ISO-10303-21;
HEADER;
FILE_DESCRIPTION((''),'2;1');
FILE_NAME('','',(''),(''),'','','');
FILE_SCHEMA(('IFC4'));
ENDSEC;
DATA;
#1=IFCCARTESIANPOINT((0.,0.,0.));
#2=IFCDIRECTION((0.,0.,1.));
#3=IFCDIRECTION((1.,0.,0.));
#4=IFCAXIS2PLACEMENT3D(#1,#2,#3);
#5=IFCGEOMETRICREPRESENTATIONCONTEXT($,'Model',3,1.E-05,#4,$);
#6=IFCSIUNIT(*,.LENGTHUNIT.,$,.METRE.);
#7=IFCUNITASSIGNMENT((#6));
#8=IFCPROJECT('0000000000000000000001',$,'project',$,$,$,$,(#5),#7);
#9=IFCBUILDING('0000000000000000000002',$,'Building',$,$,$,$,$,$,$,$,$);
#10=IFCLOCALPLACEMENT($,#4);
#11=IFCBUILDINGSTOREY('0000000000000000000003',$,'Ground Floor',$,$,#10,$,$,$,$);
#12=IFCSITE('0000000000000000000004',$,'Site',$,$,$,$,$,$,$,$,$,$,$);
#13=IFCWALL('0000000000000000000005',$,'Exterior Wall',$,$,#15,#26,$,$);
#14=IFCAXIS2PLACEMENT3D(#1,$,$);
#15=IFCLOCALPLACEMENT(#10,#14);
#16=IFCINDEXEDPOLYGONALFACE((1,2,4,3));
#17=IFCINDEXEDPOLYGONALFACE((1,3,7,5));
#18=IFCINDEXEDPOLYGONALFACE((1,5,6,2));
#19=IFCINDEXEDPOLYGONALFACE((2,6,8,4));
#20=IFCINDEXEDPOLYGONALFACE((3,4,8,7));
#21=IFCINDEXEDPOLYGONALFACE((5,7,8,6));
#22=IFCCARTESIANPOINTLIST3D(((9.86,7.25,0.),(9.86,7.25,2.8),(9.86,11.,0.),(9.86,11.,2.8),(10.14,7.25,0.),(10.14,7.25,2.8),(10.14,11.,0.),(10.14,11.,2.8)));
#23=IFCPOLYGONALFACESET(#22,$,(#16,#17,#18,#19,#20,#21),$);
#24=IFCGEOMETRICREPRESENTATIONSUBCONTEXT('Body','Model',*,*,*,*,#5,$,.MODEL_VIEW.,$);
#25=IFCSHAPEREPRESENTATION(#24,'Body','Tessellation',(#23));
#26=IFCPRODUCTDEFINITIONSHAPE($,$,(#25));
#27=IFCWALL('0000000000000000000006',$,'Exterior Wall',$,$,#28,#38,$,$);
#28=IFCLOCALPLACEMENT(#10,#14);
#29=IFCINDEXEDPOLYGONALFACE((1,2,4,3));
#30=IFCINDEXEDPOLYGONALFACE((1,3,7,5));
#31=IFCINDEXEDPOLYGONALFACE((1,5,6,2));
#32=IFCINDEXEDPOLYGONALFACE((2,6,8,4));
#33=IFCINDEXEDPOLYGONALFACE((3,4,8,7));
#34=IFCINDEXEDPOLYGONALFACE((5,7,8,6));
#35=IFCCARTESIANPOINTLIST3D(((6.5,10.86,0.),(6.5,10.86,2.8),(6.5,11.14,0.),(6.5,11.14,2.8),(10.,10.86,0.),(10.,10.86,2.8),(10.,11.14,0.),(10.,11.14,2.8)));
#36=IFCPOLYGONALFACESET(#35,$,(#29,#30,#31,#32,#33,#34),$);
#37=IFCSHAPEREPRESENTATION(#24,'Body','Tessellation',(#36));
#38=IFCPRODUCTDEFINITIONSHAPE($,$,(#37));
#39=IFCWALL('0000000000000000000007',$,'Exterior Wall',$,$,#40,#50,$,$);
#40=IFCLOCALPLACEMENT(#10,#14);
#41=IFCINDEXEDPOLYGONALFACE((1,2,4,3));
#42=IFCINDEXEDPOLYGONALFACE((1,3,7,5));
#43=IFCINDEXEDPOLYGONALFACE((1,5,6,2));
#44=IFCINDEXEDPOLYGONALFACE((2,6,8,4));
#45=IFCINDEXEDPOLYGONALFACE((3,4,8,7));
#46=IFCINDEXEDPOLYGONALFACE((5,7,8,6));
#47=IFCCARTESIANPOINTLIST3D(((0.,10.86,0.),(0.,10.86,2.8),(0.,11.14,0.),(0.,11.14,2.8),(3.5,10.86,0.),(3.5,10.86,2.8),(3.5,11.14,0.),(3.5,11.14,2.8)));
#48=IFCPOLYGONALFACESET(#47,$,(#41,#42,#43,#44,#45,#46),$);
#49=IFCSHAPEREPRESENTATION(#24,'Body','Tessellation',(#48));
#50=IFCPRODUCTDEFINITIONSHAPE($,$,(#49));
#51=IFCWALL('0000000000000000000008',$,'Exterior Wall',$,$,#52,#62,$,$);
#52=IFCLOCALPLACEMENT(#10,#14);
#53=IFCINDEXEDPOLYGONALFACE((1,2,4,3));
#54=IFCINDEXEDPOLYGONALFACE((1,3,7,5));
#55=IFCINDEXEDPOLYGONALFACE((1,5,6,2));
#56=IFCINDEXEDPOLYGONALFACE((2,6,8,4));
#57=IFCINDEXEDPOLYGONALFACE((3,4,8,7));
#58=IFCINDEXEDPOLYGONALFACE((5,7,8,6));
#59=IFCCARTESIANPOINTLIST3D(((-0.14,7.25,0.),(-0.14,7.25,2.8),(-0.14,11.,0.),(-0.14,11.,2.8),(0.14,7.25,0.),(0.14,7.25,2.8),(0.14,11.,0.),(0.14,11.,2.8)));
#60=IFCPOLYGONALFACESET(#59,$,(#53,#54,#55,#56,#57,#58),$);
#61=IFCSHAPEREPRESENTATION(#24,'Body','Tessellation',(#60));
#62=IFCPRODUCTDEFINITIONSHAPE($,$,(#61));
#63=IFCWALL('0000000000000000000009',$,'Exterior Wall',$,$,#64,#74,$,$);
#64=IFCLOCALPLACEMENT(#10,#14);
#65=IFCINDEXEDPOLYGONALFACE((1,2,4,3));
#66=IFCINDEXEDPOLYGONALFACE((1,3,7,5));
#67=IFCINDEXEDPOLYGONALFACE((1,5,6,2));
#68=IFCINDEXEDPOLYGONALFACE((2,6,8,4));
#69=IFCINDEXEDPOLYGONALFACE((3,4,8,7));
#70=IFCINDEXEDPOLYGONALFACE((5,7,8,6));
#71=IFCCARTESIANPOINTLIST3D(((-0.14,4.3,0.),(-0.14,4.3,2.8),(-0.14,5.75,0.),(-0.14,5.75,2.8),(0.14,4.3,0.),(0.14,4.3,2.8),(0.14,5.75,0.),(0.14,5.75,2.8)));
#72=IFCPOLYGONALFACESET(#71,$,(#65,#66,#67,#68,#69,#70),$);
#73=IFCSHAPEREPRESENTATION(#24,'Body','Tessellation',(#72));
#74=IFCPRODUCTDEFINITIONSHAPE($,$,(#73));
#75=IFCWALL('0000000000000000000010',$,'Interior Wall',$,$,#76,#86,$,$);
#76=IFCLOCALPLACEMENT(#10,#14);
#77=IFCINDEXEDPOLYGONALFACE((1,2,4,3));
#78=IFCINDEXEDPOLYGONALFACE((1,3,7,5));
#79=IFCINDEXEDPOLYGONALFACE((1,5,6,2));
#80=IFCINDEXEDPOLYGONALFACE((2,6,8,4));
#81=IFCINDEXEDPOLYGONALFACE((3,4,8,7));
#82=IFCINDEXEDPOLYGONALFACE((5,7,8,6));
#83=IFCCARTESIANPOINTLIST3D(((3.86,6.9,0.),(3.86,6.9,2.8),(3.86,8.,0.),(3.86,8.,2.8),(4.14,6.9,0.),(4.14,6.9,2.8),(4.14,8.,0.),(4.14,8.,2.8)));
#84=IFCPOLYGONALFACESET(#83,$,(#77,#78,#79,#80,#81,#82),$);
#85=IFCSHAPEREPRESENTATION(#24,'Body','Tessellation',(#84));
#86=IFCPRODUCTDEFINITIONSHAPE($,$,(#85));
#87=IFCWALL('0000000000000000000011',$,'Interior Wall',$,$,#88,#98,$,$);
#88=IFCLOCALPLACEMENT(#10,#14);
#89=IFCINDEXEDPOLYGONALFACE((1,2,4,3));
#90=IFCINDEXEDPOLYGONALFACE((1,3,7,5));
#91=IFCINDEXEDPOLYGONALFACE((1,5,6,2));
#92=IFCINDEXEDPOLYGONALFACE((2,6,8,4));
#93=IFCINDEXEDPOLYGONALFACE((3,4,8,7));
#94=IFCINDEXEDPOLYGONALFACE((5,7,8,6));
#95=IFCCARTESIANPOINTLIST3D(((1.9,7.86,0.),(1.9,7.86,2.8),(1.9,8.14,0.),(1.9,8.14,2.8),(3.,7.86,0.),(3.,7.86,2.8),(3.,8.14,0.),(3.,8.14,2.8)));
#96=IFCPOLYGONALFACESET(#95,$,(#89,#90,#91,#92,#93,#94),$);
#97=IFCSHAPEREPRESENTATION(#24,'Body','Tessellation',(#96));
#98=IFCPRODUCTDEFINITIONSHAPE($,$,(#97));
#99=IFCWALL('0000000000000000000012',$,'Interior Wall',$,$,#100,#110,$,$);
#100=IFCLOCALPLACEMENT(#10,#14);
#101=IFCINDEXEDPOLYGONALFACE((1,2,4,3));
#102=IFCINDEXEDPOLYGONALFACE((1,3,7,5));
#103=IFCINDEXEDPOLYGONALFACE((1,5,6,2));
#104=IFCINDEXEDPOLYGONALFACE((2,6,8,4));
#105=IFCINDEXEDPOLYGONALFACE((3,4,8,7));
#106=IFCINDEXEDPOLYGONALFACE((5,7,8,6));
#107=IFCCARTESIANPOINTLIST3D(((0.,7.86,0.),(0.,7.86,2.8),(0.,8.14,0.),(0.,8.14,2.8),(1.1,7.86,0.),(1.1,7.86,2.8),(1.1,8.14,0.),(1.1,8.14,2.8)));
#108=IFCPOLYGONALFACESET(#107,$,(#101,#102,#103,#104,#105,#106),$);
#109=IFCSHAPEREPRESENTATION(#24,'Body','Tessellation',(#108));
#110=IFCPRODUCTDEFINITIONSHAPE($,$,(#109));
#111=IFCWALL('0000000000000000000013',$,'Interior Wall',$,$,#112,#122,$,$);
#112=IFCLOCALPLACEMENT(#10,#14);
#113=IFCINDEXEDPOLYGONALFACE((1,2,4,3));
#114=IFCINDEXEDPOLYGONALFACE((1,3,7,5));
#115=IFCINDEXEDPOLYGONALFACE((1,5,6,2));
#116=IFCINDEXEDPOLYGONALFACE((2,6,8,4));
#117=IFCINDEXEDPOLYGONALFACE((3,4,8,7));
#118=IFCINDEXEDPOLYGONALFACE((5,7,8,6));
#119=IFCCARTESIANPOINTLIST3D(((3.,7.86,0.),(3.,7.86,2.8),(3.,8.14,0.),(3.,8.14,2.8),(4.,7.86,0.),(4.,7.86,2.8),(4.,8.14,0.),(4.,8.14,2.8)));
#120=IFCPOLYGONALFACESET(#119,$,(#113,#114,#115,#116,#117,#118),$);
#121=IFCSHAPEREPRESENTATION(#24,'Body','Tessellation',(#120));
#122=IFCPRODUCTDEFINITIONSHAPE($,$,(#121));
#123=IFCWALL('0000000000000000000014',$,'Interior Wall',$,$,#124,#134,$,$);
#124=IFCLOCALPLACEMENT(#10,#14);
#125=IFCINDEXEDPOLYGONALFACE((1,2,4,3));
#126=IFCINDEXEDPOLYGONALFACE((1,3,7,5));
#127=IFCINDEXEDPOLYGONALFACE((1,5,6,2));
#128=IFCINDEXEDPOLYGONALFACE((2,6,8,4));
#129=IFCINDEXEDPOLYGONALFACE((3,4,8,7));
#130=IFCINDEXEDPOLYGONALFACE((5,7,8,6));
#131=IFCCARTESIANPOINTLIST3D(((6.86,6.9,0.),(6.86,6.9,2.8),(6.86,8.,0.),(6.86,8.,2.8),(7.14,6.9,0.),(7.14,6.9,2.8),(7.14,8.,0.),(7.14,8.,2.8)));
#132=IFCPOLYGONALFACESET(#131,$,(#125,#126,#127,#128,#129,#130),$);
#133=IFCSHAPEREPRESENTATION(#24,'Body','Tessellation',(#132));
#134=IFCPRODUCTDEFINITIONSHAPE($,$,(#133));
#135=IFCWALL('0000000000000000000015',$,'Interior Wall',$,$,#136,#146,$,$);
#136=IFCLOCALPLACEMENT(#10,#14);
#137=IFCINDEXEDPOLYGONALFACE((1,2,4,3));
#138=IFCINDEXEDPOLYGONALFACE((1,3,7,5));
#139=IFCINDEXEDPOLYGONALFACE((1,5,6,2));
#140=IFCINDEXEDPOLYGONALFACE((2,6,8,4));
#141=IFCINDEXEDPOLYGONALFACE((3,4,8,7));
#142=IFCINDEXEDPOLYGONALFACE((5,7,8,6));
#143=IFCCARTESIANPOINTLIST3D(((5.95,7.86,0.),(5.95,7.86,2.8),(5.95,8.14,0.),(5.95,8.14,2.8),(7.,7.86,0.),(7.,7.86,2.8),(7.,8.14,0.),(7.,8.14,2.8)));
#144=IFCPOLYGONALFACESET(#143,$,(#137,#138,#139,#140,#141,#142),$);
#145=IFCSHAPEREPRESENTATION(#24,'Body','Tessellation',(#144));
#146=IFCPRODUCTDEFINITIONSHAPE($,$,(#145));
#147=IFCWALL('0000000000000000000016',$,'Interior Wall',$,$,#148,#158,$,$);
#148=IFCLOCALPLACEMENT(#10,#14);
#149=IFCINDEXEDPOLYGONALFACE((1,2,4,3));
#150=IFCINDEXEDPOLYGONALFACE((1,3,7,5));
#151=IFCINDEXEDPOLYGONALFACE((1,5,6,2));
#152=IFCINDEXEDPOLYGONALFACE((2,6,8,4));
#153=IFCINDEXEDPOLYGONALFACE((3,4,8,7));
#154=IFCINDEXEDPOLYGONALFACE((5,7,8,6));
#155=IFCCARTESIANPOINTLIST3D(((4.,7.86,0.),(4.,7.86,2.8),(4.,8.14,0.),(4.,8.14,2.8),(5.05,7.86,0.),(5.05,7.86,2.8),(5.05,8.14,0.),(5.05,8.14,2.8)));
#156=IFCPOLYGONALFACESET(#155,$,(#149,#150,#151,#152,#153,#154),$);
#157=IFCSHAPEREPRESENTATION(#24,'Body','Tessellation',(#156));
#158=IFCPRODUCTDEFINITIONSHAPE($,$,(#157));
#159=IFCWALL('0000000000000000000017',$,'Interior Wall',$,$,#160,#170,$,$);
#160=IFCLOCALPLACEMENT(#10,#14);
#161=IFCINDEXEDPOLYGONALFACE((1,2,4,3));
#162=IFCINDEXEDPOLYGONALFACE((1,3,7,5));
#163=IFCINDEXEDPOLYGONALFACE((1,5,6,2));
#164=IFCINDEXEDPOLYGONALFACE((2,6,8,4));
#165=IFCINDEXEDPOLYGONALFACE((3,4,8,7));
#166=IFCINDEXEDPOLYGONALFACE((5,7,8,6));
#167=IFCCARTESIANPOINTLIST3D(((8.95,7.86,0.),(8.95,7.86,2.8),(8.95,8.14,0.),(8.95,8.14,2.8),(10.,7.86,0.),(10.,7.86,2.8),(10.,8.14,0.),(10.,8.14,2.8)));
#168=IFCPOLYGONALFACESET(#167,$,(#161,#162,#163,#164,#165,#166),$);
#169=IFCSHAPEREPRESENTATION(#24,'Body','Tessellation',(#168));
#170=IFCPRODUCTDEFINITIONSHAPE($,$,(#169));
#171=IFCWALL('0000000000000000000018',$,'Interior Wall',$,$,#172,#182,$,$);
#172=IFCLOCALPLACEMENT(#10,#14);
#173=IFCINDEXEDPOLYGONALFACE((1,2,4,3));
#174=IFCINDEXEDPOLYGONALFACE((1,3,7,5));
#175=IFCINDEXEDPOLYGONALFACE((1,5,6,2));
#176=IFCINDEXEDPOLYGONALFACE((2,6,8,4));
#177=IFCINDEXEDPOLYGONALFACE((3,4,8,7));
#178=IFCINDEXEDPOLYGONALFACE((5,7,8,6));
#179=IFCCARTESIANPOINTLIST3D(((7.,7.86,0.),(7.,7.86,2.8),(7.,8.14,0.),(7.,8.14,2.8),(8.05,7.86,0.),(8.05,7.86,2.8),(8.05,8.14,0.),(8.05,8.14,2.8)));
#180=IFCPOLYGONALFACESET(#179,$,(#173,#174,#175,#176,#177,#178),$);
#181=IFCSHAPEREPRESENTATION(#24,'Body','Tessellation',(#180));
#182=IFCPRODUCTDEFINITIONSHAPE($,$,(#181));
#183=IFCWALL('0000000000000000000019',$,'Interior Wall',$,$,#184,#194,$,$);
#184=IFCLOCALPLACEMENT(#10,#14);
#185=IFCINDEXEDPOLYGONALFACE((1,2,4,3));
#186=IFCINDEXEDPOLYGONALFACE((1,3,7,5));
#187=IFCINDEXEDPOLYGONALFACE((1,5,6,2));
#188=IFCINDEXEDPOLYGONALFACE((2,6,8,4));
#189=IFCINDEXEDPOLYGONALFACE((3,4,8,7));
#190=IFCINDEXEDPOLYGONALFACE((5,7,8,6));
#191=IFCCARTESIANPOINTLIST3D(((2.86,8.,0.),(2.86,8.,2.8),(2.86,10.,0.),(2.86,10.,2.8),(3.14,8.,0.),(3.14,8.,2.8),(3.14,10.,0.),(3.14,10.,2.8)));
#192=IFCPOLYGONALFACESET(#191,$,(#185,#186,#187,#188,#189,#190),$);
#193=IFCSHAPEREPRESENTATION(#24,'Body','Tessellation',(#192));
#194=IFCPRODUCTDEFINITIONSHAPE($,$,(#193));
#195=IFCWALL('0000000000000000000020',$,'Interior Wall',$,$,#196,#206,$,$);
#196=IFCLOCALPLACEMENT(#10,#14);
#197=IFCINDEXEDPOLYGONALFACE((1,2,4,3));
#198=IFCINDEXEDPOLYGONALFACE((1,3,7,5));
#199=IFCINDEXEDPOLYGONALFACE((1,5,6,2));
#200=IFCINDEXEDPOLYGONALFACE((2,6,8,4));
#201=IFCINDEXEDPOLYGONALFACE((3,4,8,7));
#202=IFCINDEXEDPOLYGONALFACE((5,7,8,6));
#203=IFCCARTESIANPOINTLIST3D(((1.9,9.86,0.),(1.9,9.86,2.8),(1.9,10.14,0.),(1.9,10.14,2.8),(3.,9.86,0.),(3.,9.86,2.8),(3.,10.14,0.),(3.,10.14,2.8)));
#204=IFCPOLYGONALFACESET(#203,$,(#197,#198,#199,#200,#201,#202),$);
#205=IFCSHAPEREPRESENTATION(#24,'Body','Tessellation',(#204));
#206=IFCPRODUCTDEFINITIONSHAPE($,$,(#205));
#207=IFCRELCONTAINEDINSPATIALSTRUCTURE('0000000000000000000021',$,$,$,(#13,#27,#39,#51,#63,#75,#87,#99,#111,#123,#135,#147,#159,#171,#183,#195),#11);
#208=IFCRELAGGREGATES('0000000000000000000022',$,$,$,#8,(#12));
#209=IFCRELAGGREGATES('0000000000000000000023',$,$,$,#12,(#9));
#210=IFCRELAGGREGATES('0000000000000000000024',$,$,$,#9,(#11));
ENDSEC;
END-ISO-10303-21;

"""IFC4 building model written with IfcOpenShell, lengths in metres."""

from ifc_helpers import new_model, si_unit, frame, origin_with_axes, place, context, subcontext, project, spatial, indexed_curve, outline, extrude, element, save


model = new_model("IFC4")

# Units and contexts
model_context = context("Model", 3, precision=1e-05, world=origin_with_axes())
body_context = subcontext(model_context, "Body", "Model", "MODEL_VIEW")
ifc_project = project(units=[si_unit("LENGTHUNIT", "METRE")], contexts=[model_context])

# Site, building, storey
site = spatial("IfcSite", under=ifc_project, Name="Site")
building = spatial("IfcBuilding", under=site, Name="Building")
storey_placement = place(None, origin_with_axes())
storey = spatial("IfcBuildingStorey", under=building, at=storey_placement, Name="Ground Floor")

# Walls
wall_1_placement = place(storey_placement, frame((10.0, 7.25, 0.0), z_axis=(0.0, 0.0, 1.0), x_axis=(0.0, 1.0, 0.0)))
element("IfcWall", 1, at=wall_1_placement, inside=storey, Name="Exterior Wall", context=body_context, shape_type="SweptSolid", body=[
    extrude(outline(indexed_curve([(0.0, 0.0), (0.0, 0.28), (3.75, 0.28), (3.75, 0.0), (0.0, 0.0)], self_intersect=False)), frame((0.0, -0.14, 0.0), z_axis=(0.0, 0.0, 1.0), x_axis=(1.0, 0.0, 0.0)), (0.0, 0.0, 1.0), 2.8),
])
for number, where, z_axis, x_axis, name in (
    (2, (10.0, 11.0, 0.0), (0.0, 0.0, 1.0), (-1.0, 0.0, 0.0), "Exterior Wall"),
    (3, (3.5, 11.0, 0.0), (0.0, 0.0, 1.0), (-1.0, 0.0, 0.0), "Exterior Wall"),
):
    element("IfcWall", number, at=place(storey_placement, frame(where, z_axis=z_axis, x_axis=x_axis)), inside=storey, Name=name, context=body_context, shape_type="SweptSolid", body=[
        extrude(outline(indexed_curve([(0.0, 0.0), (0.0, 0.28), (3.5, 0.28), (3.5, 0.0), (0.0, 0.0)], self_intersect=False)), frame((0.0, -0.14, 0.0), z_axis=(0.0, 0.0, 1.0), x_axis=(1.0, 0.0, 0.0)), (0.0, 0.0, 1.0), 2.8),
    ])
wall_2_placement = place(storey_placement, frame((0.0, 11.0, 0.0), z_axis=(0.0, 0.0, 1.0), x_axis=(0.0, -1.0, 0.0)))
element("IfcWall", 4, at=wall_2_placement, inside=storey, Name="Exterior Wall", context=body_context, shape_type="SweptSolid", body=[
    extrude(outline(indexed_curve([(0.0, 0.0), (0.0, 0.28), (3.75, 0.28), (3.75, 0.0), (0.0, 0.0)], self_intersect=False)), frame((0.0, -0.14, 0.0), z_axis=(0.0, 0.0, 1.0), x_axis=(1.0, 0.0, 0.0)), (0.0, 0.0, 1.0), 2.8),
])
wall_3_placement = place(storey_placement, frame((0.0, 5.75, 0.0), z_axis=(0.0, 0.0, 1.0), x_axis=(0.0, -1.0, 0.0)))
element("IfcWall", 5, at=wall_3_placement, inside=storey, Name="Exterior Wall", context=body_context, shape_type="SweptSolid", body=[
    extrude(outline(indexed_curve([(0.0, 0.0), (0.0, 0.28), (1.45, 0.28), (1.45, 0.0), (0.0, 0.0)], self_intersect=False)), frame((0.0, -0.14, 0.0), z_axis=(0.0, 0.0, 1.0), x_axis=(1.0, 0.0, 0.0)), (0.0, 0.0, 1.0), 2.8),
])
wall_4_placement = place(storey_placement, frame((4.0, 6.9, 0.0), z_axis=(0.0, 0.0, 1.0), x_axis=(0.0, 1.0, 0.0)))
element("IfcWall", 6, at=wall_4_placement, inside=storey, Name="Interior Wall", context=body_context, shape_type="SweptSolid", body=[
    extrude(outline(indexed_curve([(0.0, 0.0), (0.0, 0.28), (1.1, 0.28), (1.1, 0.0), (0.0, 0.0)], self_intersect=False)), frame((0.0, -0.14, 0.0), z_axis=(0.0, 0.0, 1.0), x_axis=(1.0, 0.0, 0.0)), (0.0, 0.0, 1.0), 2.8),
])
for number, where, z_axis, x_axis, name in (
    (7, (3.0, 8.0, 0.0), (0.0, 0.0, 1.0), (-1.0, 0.0, 0.0), "Interior Wall"),
    (8, (1.1, 8.0, 0.0), (0.0, 0.0, 1.0), (-1.0, 0.0, 0.0), "Interior Wall"),
):
    element("IfcWall", number, at=place(storey_placement, frame(where, z_axis=z_axis, x_axis=x_axis)), inside=storey, Name=name, context=body_context, shape_type="SweptSolid", body=[
        extrude(outline(indexed_curve([(0.0, 0.0), (0.0, 0.28), (1.1, 0.28), (1.1, 0.0), (0.0, 0.0)], self_intersect=False)), frame((0.0, -0.14, 0.0), z_axis=(0.0, 0.0, 1.0), x_axis=(1.0, 0.0, 0.0)), (0.0, 0.0, 1.0), 2.8),
    ])
wall_5_placement = place(storey_placement, frame((4.0, 8.0, 0.0), z_axis=(0.0, 0.0, 1.0), x_axis=(-1.0, 0.0, 0.0)))
element("IfcWall", 9, at=wall_5_placement, inside=storey, Name="Interior Wall", context=body_context, shape_type="SweptSolid", body=[
    extrude(outline(indexed_curve([(0.0, 0.0), (0.0, 0.28), (1.0, 0.28), (1.0, 0.0), (0.0, 0.0)], self_intersect=False)), frame((0.0, -0.14, 0.0), z_axis=(0.0, 0.0, 1.0), x_axis=(1.0, 0.0, 0.0)), (0.0, 0.0, 1.0), 2.8),
])
wall_6_placement = place(storey_placement, frame((7.0, 6.9, 0.0), z_axis=(0.0, 0.0, 1.0), x_axis=(0.0, 1.0, 0.0)))
element("IfcWall", 10, at=wall_6_placement, inside=storey, Name="Interior Wall", context=body_context, shape_type="SweptSolid", body=[
    extrude(outline(indexed_curve([(0.0, 0.0), (0.0, 0.28), (1.1, 0.28), (1.1, 0.0), (0.0, 0.0)], self_intersect=False)), frame((0.0, -0.14, 0.0), z_axis=(0.0, 0.0, 1.0), x_axis=(1.0, 0.0, 0.0)), (0.0, 0.0, 1.0), 2.8),
])
for number, where, z_axis, x_axis, name in (
    (11, (7.0, 8.0, 0.0), (0.0, 0.0, 1.0), (-1.0, 0.0, 0.0), "Interior Wall"),
    (12, (5.05, 8.0, 0.0), (0.0, 0.0, 1.0), (-1.0, 0.0, 0.0), "Interior Wall"),
):
    element("IfcWall", number, at=place(storey_placement, frame(where, z_axis=z_axis, x_axis=x_axis)), inside=storey, Name=name, context=body_context, shape_type="SweptSolid", body=[
        extrude(outline(indexed_curve([(0.0, 0.0), (0.0, 0.28), (1.05, 0.28), (1.05, 0.0), (0.0, 0.0)], self_intersect=False)), frame((0.0, -0.14, 0.0), z_axis=(0.0, 0.0, 1.0), x_axis=(1.0, 0.0, 0.0)), (0.0, 0.0, 1.0), 2.8),
    ])
for number, where, z_axis, x_axis, name in (
    (13, (10.0, 8.0, 0.0), (0.0, 0.0, 1.0), (-1.0, 0.0, 0.0), "Interior Wall"),
    (14, (8.05, 8.0, 0.0), (0.0, 0.0, 1.0), (-1.0, 0.0, 0.0), "Interior Wall"),
):
    element("IfcWall", number, at=place(storey_placement, frame(where, z_axis=z_axis, x_axis=x_axis)), inside=storey, Name=name, context=body_context, shape_type="SweptSolid", body=[
        extrude(outline(indexed_curve([(0.0, 0.0), (0.0, 0.28), (1.05, 0.28), (1.05, 0.0), (0.0, 0.0)], self_intersect=False)), frame((0.0, -0.14, 0.0), z_axis=(0.0, 0.0, 1.0), x_axis=(1.0, 0.0, 0.0)), (0.0, 0.0, 1.0), 2.8),
    ])
wall_7_placement = place(storey_placement, frame((3.0, 8.0, 0.0), z_axis=(0.0, 0.0, 1.0), x_axis=(0.0, 1.0, 0.0)))
element("IfcWall", 15, at=wall_7_placement, inside=storey, Name="Interior Wall", context=body_context, shape_type="SweptSolid", body=[
    extrude(outline(indexed_curve([(0.0, 0.0), (0.0, 0.28), (2.0, 0.28), (2.0, 0.0), (0.0, 0.0)], self_intersect=False)), frame((0.0, -0.14, 0.0), z_axis=(0.0, 0.0, 1.0), x_axis=(1.0, 0.0, 0.0)), (0.0, 0.0, 1.0), 2.8),
])
for number, where, z_axis, x_axis, name in (
    (16, (3.0, 10.0, 0.0), (0.0, 0.0, 1.0), (-1.0, 0.0, 0.0), "Interior Wall"),
):
    element("IfcWall", number, at=place(storey_placement, frame(where, z_axis=z_axis, x_axis=x_axis)), inside=storey, Name=name, context=body_context, shape_type="SweptSolid", body=[
        extrude(outline(indexed_curve([(0.0, 0.0), (0.0, 0.28), (1.1, 0.28), (1.1, 0.0), (0.0, 0.0)], self_intersect=False)), frame((0.0, -0.14, 0.0), z_axis=(0.0, 0.0, 1.0), x_axis=(1.0, 0.0, 0.0)), (0.0, 0.0, 1.0), 2.8),
    ])

save(model, "model.ifc")
